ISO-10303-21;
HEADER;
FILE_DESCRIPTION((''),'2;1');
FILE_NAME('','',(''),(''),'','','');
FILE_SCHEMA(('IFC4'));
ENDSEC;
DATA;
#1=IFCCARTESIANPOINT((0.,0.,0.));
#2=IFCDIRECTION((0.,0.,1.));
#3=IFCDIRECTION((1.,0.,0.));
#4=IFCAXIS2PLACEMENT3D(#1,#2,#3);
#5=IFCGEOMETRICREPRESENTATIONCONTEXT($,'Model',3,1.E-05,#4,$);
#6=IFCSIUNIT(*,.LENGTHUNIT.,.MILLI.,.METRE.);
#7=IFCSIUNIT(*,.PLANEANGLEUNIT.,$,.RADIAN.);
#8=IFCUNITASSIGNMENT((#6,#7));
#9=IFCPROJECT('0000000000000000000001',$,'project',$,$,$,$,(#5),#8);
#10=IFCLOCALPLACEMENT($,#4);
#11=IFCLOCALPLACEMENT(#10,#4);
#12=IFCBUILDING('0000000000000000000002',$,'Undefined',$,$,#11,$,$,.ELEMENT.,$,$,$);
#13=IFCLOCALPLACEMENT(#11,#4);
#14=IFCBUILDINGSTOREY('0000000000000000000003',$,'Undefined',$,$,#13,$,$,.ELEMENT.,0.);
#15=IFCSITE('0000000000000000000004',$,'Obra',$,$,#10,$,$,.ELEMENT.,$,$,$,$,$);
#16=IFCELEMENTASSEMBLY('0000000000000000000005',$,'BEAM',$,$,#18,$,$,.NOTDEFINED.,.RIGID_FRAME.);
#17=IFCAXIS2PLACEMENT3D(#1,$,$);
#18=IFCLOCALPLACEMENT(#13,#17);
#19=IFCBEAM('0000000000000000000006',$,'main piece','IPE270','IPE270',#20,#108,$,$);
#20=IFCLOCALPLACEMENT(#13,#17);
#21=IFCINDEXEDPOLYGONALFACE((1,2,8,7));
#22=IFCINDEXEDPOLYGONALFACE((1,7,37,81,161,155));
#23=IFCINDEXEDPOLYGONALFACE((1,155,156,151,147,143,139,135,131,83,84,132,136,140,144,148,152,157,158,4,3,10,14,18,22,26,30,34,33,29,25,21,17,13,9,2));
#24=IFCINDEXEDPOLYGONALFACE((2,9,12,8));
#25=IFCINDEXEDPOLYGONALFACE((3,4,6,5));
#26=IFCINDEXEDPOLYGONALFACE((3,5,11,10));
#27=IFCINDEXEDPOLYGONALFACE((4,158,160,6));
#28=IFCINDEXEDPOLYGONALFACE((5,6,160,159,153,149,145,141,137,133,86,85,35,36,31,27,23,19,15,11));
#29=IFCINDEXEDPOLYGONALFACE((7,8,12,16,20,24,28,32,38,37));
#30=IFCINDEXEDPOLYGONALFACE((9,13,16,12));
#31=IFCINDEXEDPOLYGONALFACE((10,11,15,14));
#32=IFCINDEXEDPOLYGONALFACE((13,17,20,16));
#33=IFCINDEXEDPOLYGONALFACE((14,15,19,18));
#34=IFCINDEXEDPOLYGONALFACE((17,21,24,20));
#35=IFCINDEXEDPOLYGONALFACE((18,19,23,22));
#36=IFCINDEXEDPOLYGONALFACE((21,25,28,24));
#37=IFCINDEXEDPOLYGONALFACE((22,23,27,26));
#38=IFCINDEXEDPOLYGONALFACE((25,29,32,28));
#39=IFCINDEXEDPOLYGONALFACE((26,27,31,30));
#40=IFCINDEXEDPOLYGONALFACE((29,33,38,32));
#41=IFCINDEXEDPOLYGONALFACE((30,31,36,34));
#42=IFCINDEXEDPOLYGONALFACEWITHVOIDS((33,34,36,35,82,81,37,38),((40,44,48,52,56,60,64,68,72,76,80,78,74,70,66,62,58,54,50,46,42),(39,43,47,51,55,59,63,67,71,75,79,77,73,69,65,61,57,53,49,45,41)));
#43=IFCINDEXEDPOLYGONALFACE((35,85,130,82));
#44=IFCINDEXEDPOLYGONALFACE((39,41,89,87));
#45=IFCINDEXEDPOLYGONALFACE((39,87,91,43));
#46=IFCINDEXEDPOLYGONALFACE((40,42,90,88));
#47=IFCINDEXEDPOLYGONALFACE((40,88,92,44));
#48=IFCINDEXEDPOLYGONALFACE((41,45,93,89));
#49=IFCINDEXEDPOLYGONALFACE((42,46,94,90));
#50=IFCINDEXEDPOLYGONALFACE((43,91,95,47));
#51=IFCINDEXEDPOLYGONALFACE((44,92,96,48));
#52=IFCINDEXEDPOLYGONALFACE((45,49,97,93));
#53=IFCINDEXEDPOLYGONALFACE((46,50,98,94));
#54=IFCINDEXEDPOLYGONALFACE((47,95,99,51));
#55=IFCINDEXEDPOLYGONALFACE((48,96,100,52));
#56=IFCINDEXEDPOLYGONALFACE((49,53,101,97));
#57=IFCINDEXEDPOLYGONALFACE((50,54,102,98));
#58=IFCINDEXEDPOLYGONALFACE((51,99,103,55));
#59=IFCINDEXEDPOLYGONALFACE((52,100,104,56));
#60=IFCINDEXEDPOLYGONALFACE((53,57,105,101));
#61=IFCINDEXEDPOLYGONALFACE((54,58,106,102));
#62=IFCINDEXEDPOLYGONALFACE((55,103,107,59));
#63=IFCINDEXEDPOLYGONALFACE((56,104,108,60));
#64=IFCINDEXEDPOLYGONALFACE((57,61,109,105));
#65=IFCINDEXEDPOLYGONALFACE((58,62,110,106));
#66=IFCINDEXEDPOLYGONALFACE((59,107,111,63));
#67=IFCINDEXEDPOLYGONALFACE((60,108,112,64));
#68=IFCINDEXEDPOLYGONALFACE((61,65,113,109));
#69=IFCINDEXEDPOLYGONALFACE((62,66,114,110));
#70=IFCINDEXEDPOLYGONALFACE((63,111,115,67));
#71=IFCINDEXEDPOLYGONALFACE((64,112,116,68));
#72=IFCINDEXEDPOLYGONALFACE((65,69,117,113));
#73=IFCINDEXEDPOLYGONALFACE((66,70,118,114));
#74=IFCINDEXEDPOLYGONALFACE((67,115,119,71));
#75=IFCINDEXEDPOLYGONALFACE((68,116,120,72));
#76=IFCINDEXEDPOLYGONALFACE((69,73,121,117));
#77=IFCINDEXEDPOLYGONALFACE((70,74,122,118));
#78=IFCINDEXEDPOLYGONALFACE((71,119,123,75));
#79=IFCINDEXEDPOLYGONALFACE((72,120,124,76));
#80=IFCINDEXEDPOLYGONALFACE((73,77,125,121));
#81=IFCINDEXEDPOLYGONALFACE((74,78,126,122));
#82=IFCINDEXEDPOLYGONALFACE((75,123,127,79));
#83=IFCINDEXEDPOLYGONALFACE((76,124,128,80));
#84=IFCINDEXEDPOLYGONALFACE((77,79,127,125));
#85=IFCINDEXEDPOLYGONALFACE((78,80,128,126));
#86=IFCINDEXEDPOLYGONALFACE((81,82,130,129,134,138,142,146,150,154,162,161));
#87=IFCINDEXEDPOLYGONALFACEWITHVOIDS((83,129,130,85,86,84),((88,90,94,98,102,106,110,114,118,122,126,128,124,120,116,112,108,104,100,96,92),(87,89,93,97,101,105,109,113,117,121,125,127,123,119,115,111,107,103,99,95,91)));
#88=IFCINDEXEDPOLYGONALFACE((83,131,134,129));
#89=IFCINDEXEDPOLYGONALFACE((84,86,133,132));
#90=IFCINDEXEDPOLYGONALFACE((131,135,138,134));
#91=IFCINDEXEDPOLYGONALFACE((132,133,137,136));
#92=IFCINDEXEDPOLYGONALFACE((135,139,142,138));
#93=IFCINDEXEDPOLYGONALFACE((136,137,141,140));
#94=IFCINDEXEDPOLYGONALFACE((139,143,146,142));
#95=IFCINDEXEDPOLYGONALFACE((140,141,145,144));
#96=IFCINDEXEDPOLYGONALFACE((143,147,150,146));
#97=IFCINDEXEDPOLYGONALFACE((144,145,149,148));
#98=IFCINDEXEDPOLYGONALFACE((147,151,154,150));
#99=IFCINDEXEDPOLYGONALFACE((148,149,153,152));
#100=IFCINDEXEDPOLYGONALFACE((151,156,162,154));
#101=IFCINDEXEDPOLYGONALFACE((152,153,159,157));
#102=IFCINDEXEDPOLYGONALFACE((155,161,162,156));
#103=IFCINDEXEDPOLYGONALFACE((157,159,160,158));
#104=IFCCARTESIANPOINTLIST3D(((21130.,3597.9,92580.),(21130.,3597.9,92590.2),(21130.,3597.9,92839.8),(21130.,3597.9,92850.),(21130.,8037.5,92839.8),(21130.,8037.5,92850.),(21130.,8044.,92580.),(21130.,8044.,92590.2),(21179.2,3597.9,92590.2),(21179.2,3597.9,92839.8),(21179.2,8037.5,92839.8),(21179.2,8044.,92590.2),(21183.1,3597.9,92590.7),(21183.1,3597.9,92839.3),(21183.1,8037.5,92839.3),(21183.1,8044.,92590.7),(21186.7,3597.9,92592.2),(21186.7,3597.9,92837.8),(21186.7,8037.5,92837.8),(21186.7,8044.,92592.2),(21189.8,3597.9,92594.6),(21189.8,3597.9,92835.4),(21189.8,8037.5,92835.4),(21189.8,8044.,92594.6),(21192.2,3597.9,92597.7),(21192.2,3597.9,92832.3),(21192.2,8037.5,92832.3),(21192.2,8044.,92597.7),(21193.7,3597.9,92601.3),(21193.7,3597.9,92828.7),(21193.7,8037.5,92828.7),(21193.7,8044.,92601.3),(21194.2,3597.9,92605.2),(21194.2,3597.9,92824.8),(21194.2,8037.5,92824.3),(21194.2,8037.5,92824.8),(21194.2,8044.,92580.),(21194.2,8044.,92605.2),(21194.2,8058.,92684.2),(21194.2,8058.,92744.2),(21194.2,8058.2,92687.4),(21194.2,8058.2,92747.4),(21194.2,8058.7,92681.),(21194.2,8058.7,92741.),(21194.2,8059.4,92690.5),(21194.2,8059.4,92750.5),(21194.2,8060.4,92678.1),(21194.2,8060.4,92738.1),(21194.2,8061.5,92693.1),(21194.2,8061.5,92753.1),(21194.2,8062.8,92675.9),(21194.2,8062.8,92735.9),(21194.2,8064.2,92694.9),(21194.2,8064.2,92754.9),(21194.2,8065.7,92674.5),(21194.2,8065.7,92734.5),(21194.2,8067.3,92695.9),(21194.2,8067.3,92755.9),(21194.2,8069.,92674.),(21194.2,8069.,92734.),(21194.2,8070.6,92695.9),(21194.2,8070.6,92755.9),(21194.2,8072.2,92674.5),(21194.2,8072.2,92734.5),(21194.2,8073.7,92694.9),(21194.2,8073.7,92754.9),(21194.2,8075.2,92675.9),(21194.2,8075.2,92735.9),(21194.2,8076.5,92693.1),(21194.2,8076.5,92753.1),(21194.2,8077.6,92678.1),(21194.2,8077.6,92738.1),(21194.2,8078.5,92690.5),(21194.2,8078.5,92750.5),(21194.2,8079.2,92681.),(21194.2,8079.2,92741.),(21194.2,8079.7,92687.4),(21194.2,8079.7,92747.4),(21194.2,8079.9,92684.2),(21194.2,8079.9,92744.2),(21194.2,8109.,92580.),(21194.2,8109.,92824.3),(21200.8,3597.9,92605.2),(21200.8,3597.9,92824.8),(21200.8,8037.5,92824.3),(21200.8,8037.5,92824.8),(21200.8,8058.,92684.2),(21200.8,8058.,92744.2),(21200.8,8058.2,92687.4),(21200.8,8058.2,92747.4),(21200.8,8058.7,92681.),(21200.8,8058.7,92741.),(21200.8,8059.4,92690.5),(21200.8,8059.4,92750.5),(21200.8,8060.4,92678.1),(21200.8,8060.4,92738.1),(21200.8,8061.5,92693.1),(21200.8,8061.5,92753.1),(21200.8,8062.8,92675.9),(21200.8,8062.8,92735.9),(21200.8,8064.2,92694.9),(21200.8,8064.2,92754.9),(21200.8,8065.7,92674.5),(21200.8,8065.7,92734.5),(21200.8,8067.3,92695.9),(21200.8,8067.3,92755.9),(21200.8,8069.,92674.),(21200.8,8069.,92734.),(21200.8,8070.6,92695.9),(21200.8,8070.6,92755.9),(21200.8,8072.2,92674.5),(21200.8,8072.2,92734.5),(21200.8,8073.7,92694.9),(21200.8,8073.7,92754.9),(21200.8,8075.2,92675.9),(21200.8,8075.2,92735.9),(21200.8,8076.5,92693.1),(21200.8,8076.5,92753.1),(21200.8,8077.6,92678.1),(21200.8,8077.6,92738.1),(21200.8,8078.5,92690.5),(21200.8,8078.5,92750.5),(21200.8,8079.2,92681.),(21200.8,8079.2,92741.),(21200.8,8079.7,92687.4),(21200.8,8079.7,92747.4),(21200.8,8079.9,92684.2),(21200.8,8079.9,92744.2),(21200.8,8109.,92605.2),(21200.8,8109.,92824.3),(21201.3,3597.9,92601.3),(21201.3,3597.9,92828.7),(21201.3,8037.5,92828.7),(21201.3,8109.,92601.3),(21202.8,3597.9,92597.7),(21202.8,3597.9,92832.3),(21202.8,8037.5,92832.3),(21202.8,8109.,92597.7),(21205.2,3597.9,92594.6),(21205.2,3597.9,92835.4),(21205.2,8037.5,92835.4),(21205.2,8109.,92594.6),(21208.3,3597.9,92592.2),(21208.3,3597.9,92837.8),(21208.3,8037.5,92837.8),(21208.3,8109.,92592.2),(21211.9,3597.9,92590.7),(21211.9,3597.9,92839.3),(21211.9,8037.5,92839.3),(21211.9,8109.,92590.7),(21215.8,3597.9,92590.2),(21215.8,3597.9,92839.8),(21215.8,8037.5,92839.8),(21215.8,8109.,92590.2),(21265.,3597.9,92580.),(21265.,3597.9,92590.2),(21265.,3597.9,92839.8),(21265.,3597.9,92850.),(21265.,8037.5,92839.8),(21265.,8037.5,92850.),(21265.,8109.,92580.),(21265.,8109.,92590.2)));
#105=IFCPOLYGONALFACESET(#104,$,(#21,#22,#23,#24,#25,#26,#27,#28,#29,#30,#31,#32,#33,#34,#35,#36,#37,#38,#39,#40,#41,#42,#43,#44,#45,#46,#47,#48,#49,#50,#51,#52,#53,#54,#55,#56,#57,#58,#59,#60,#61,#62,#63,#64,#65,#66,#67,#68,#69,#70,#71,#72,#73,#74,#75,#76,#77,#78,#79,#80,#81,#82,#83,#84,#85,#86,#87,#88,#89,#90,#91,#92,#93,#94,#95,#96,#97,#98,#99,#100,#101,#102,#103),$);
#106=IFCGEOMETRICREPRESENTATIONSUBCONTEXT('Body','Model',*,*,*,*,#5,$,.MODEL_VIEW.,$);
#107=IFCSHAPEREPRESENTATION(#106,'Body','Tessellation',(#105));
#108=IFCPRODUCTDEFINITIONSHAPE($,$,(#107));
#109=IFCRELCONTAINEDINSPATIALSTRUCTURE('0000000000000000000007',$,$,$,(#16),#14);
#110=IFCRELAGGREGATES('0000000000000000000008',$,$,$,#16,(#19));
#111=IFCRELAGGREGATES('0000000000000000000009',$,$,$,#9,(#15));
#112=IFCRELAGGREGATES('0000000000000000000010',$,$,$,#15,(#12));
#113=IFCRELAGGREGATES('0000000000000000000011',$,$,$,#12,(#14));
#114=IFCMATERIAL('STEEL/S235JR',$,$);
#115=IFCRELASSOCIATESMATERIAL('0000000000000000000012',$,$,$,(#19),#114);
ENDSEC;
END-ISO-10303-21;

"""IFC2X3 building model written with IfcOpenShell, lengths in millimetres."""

from ifc_helpers import new_model, si_unit, frame, origin_with_axes, origin_2d_with_axis, place, context, subcontext, project, spatial, rectangle, circle, i_section, extrude, clip, halfspace, source, transform, mapped, material, element, aggregate, save


model = new_model("IFC2X3")

# Units and contexts
model_context = context("Model", 3, precision=1e-05, world=origin_with_axes())
body_context = subcontext(model_context, "Body", "Model", "MODEL_VIEW")
ifc_project = project(units=[si_unit("LENGTHUNIT", "METRE", prefix="MILLI"), si_unit("PLANEANGLEUNIT", "RADIAN")], contexts=[model_context])

# Site, building, storey
site_placement = place(None, origin_with_axes())
site = spatial("IfcSite", under=ifc_project, at=site_placement, Name="Obra", CompositionType="ELEMENT")
building_placement = place(site_placement, origin_with_axes())
building = spatial("IfcBuilding", under=site, at=building_placement, Name="Undefined", CompositionType="ELEMENT")
storey_placement = place(building_placement, origin_with_axes())
storey = spatial("IfcBuildingStorey", under=building, at=storey_placement, Name="Undefined", CompositionType="ELEMENT", Elevation=0.0)

# Shared definitions
ifc_material = material(Name="STEEL/S235JR")

# Element assembly, beam, openings
assembly_1_placement = place(storey_placement, origin_with_axes())
assembly_1 = element("IfcElementAssembly", 1, at=assembly_1_placement, inside=storey, Name="BEAM", AssemblyPlace="NOTDEFINED", PredefinedType="RIGID_FRAME")
beam_1_placement = place(assembly_1_placement, frame((21197.5, 3598.0, 92715.0), z_axis=(0.0, 0.0, 1.0), x_axis=(0.0, 1.0, 0.0)))
beam_1 = element("IfcBeam", 2, at=beam_1_placement, material=ifc_material, Name="main piece", Description="IPE270", ObjectType="IPE270", context=body_context, shape_type="Clipping", body=[
    clip(extrude(i_section(OverallWidth=135.0, OverallDepth=270.0, WebThickness=6.6, FlangeThickness=10.2, FilletRadius=15.0, at=origin_2d_with_axis()), frame((4511.0, 0.0, 0.0), z_axis=(-1.0, 0.0, 0.0), x_axis=(0.0, -1.0, 0.0)), (0.0, 0.0, 1.0), 4511.0), halfspace(frame((4511.0, 0.0, -235.0), z_axis=(-1.0, 0.0, 0.0), x_axis=(0.0, 1.0, 0.0)), True)),
])
opening_1_placement = place(assembly_1_placement, frame((21197.5, 3598.0, 92715.0), z_axis=(0.0, 0.0, 1.0), x_axis=(0.0, 1.0, 0.0)))
element("IfcOpeningElement", 3, at=opening_1_placement, cuts=beam_1, ObjectType="Recess", context=body_context, shape_type="SweptSolid", body=[
    extrude(rectangle(XDim=75.0, YDim=300.0, at=origin_2d_with_axis()), frame((4483.5, 153.3, 124.3), z_axis=(0.0, 0.0, -1.0), x_axis=(-1.0, 0.0, 0.0)), (0.0, 0.0, 1.0), 278.6),
])
opening_2_placement = place(assembly_1_placement, frame((21197.5, 3598.0, 92715.0), z_axis=(0.0, 0.0, 1.0), x_axis=(0.0, 1.0, 0.0)))
element("IfcOpeningElement", 4, at=opening_2_placement, cuts=beam_1, ObjectType="Recess", context=body_context, shape_type="SweptSolid", body=[
    extrude(rectangle(XDim=26.7, YDim=83.5, at=origin_2d_with_axis()), frame((4481.3, 68.5, 122.7), z_axis=(0.0, -1.0, 0.0), x_axis=(0.0, 0.0, -1.0)), (0.0, 0.0, 1.0), 137.0),
])
shared_shape = source(origin_with_axes(), body_context, "Body", "SweptSolid", [
    extrude(circle(Radius=11.0, at=origin_2d_with_axis()), frame((0.0, -3.4, 0.0), z_axis=(0.0, 1.0, 0.0), x_axis=(1.0, 0.0, 0.0)), (0.0, 0.0, 1.0), 6.8),
])
opening_3_placement = place(assembly_1_placement, frame((21197.5, 8109.0, 92850.0), z_axis=(0.0, -1.0, 0.0), x_axis=(0.0, 0.0, -1.0)))
element("IfcOpeningElement", 5, at=opening_3_placement, cuts=beam_1, ObjectType="Opening", context=body_context, shape_type="MappedRepresentation", body=[
    mapped(shared_shape, transform((105.0, 0.0, 40.0))),
    mapped(shared_shape, transform((165.0, 0.0, 40.0))),
])
aggregate(assembly_1, [beam_1])

save(model, "model.ifc")
